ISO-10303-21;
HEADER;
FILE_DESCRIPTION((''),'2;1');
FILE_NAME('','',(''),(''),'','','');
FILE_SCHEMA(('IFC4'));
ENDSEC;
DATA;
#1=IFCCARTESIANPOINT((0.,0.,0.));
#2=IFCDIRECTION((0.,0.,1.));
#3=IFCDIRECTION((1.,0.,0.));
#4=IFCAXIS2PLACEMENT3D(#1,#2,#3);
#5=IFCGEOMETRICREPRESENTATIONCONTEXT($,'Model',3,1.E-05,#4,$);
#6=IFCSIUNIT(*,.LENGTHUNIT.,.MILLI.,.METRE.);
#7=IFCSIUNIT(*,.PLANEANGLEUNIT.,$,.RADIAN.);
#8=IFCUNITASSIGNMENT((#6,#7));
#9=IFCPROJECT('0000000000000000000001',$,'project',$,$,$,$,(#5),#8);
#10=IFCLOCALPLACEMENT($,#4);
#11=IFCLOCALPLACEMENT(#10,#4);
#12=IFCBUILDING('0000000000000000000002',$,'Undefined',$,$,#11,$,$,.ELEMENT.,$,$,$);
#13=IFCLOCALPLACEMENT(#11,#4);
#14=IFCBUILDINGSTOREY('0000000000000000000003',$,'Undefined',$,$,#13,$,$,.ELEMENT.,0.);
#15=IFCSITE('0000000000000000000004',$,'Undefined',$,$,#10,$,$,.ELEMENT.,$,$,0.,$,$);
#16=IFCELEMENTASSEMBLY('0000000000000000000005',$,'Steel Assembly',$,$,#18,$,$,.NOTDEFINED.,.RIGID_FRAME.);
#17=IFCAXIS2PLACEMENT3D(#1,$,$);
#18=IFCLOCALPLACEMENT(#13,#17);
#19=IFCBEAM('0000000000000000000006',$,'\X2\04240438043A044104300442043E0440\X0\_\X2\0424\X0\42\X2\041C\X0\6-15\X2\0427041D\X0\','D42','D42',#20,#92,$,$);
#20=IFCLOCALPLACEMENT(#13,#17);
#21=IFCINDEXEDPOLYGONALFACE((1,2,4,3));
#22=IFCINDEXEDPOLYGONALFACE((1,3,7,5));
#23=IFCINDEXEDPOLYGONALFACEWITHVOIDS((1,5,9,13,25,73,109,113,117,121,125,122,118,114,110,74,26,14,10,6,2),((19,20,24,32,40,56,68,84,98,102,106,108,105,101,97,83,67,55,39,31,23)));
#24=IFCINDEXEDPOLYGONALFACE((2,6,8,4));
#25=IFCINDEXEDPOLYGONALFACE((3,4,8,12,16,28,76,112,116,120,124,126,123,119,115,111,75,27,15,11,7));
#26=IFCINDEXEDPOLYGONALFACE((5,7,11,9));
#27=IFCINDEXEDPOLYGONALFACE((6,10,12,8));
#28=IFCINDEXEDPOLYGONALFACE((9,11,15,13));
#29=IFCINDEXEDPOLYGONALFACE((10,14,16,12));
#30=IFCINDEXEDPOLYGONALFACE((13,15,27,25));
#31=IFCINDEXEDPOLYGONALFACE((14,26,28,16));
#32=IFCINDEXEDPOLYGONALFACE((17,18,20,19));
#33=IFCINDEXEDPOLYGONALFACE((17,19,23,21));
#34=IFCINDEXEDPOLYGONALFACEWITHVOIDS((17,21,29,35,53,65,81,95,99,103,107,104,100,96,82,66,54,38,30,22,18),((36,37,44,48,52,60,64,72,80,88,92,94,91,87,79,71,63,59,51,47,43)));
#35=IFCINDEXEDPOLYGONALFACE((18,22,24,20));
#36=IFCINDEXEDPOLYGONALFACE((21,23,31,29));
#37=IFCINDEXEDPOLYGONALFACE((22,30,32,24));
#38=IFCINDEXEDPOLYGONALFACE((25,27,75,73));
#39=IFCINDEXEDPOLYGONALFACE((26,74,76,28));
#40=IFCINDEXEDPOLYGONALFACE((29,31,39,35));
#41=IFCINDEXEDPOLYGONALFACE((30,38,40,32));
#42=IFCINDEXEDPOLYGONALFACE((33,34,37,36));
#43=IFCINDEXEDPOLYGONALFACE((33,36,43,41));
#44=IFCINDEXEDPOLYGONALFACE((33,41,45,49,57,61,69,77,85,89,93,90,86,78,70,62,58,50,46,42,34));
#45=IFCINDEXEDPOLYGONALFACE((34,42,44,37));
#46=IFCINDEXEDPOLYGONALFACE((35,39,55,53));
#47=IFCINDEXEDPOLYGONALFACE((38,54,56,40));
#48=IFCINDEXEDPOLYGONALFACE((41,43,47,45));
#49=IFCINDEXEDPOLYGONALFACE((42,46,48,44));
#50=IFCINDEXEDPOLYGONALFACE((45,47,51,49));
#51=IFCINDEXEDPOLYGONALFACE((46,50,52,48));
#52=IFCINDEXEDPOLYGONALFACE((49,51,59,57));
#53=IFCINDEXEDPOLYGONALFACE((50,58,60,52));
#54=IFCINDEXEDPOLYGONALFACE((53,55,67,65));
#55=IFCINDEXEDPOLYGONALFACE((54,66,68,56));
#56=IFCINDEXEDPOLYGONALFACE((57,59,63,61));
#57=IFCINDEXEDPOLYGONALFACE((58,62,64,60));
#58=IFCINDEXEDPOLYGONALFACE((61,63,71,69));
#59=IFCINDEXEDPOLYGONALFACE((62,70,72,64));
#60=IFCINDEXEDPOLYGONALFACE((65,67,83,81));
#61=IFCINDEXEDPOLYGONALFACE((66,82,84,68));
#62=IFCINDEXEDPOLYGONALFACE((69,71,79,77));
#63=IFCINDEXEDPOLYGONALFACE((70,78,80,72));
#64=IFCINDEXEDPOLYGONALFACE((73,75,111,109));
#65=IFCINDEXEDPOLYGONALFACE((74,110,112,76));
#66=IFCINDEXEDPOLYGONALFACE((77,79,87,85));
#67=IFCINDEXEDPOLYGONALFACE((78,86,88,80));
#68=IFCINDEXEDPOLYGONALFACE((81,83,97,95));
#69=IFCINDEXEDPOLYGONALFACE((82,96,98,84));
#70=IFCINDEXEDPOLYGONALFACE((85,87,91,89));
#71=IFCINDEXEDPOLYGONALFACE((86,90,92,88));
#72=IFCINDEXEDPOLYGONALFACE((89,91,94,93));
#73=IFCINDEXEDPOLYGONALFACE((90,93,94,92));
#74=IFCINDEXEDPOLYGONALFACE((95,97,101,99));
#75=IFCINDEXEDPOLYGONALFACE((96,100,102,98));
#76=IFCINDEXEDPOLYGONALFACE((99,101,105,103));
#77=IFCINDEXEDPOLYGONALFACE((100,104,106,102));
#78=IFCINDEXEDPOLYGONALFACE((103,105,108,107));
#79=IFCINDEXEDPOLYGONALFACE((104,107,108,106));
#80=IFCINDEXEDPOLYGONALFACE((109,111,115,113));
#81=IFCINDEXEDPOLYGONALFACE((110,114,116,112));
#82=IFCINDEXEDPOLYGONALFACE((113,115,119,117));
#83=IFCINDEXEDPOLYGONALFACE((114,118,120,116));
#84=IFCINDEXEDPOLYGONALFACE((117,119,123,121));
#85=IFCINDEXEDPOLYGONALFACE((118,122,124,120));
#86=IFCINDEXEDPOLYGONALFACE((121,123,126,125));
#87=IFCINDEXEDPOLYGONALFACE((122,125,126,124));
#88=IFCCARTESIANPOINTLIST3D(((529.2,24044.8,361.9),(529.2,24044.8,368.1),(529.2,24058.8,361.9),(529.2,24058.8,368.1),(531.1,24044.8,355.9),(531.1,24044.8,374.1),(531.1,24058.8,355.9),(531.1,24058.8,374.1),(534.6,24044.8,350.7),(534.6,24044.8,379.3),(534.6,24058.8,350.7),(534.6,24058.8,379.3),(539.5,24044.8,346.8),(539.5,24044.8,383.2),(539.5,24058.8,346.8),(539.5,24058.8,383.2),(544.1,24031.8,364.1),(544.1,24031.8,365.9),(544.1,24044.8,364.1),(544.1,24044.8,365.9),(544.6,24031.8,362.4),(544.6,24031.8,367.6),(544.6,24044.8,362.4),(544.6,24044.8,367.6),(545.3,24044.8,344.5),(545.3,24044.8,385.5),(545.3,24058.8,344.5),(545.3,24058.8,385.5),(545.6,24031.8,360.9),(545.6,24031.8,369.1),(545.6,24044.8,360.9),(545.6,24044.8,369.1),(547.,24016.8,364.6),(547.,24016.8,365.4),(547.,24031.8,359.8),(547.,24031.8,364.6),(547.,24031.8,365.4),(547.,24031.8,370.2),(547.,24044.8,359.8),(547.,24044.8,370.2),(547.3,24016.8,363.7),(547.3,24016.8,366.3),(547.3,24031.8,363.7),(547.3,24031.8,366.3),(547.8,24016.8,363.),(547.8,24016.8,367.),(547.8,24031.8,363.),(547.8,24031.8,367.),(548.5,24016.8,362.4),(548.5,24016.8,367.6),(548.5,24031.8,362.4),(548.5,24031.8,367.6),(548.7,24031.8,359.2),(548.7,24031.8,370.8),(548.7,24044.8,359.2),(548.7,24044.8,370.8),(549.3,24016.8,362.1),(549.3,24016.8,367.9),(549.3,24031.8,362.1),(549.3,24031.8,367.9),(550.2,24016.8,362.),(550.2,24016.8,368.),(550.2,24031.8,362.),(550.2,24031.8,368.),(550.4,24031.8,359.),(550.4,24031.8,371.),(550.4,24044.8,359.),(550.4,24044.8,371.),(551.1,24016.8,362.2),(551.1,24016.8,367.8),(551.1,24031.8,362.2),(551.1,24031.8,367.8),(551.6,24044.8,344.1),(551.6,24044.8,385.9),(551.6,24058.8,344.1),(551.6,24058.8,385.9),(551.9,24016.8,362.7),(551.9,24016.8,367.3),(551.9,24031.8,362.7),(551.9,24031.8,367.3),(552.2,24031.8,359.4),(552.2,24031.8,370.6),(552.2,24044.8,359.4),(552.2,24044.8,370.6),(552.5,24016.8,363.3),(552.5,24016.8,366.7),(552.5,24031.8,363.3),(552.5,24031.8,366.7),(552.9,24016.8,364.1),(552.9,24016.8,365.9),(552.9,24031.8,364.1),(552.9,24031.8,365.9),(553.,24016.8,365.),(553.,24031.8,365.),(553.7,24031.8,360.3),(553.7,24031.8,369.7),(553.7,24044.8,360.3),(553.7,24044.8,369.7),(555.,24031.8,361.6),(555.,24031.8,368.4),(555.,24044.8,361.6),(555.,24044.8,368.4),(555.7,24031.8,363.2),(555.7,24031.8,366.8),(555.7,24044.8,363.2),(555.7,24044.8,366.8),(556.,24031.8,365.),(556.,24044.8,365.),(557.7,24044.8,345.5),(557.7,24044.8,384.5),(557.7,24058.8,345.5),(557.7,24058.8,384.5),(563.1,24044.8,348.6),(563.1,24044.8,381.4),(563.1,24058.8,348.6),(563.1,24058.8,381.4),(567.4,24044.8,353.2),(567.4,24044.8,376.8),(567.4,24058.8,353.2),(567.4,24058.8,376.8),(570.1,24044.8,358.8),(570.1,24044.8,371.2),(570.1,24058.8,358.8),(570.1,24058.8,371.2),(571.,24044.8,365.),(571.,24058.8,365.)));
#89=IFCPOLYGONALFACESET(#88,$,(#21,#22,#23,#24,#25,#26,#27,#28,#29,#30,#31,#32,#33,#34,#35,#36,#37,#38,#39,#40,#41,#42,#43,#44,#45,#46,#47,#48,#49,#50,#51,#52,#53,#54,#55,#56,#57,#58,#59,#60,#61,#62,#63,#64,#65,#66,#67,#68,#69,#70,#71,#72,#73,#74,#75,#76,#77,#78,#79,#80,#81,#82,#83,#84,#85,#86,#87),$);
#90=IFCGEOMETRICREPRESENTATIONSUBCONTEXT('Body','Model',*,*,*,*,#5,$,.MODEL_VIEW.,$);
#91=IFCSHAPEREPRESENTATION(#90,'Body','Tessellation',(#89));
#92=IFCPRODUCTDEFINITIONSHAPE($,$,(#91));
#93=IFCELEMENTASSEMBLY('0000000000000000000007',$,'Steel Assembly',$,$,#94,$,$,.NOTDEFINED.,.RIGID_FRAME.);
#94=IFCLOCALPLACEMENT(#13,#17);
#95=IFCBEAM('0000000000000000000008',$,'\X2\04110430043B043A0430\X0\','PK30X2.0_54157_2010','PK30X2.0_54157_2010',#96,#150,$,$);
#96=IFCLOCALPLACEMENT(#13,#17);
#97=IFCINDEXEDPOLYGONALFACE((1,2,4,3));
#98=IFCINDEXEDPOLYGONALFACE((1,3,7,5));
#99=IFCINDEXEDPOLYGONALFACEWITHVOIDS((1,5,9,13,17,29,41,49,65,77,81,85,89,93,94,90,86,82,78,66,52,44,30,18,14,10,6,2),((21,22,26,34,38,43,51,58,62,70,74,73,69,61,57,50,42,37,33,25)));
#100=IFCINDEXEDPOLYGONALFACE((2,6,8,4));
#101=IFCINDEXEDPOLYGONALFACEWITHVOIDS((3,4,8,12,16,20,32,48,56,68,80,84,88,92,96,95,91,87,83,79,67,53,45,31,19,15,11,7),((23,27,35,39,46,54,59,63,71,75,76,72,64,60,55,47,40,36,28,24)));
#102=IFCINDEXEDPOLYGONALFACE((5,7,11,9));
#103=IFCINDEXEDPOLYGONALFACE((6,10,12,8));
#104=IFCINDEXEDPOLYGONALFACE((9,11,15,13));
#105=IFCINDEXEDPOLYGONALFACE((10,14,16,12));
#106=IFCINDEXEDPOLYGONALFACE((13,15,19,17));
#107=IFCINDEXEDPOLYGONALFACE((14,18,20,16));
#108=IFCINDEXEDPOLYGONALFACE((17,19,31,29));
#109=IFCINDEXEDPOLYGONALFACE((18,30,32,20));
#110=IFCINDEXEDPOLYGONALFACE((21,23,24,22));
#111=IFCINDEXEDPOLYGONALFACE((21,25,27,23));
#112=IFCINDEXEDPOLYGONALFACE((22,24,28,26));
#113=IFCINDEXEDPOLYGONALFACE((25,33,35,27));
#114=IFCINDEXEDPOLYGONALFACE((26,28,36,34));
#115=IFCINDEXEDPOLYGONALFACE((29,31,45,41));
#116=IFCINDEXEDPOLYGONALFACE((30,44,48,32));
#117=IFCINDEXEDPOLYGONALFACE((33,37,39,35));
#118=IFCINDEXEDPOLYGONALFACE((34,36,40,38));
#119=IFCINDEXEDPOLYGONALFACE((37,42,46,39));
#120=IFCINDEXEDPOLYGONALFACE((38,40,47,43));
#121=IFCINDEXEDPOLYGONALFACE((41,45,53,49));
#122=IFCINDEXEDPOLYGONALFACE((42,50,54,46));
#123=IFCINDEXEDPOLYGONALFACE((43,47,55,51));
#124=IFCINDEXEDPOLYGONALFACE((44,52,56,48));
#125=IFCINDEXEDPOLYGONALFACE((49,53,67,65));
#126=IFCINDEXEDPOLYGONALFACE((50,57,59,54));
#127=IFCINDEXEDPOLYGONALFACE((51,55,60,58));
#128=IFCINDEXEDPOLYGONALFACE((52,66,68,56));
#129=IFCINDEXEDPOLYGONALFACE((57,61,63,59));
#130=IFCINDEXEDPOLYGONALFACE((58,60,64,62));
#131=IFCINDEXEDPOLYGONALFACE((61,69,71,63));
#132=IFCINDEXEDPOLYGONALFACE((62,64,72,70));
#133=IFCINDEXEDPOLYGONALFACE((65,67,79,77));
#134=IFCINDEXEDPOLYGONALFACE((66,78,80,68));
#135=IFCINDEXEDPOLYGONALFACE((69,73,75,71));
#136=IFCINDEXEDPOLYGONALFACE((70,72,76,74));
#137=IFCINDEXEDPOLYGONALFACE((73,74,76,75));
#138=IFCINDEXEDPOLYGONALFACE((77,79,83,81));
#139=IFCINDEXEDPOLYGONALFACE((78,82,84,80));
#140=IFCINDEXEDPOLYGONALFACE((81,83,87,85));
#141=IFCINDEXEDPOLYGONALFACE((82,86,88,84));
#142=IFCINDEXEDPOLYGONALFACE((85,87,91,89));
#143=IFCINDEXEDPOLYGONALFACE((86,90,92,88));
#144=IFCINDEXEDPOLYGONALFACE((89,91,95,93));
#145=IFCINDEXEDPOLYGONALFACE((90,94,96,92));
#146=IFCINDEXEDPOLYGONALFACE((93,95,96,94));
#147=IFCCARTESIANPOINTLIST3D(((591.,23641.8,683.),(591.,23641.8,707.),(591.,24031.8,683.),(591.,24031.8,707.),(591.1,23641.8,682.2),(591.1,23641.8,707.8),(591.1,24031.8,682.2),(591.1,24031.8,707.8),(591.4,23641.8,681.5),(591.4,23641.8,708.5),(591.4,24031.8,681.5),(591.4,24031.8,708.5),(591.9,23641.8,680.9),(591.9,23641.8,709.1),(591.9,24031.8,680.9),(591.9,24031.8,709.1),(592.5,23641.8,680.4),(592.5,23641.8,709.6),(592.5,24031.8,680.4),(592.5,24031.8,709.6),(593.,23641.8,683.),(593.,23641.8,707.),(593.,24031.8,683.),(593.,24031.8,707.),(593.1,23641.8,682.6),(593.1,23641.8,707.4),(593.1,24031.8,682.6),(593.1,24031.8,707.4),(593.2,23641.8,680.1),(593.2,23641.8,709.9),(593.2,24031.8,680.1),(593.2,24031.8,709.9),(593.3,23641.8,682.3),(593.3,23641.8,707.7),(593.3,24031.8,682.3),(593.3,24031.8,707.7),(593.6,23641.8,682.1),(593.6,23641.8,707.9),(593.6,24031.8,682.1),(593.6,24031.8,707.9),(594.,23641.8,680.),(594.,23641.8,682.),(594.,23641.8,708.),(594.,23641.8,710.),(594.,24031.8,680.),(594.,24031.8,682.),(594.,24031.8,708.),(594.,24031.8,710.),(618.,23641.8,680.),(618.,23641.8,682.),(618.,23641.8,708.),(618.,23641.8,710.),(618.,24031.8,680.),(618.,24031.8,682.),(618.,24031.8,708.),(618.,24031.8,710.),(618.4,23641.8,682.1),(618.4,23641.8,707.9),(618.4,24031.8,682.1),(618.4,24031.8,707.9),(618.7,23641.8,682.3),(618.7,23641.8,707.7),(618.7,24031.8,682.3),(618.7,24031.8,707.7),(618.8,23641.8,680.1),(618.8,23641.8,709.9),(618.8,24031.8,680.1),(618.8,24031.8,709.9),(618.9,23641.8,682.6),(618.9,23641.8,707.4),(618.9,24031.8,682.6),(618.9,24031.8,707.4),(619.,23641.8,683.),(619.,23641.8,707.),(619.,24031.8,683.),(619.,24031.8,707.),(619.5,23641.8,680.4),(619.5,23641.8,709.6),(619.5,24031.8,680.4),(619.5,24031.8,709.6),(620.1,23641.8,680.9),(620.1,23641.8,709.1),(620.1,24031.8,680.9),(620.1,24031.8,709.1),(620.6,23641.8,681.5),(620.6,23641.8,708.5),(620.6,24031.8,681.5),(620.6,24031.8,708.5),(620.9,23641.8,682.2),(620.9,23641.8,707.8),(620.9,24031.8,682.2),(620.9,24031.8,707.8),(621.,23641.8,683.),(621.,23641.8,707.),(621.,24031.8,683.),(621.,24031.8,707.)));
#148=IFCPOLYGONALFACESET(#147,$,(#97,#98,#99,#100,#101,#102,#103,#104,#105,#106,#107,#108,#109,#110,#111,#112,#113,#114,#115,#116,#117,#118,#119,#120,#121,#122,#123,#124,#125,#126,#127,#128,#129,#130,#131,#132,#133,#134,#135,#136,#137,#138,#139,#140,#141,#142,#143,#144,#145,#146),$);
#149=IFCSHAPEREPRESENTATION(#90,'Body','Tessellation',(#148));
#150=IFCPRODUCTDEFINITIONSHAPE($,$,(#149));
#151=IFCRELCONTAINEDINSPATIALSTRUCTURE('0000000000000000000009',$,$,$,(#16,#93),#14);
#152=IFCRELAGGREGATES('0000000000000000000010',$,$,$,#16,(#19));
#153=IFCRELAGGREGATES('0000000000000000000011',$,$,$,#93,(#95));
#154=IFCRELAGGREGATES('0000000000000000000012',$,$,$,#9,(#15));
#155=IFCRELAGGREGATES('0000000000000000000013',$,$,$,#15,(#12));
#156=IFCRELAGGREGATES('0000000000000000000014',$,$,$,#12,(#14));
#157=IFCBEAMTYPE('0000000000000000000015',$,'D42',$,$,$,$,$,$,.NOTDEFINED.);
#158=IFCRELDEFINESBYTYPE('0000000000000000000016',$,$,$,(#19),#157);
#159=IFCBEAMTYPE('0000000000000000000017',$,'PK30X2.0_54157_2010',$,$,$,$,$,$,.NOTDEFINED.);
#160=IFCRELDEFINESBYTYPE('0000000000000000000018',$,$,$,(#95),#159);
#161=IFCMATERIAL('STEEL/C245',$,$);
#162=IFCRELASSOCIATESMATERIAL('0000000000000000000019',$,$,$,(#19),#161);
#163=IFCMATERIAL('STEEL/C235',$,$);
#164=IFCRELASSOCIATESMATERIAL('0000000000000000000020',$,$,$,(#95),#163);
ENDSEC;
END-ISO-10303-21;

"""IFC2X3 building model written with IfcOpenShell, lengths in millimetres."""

from ifc_helpers import new_model, si_unit, frame, origin_with_axes, origin_2d_with_axis, place, context, subcontext, project, spatial, hollow_rectangle, circle, extrude, boolean, material, type_object, element, aggregate, save


model = new_model("IFC2X3")

# Units and contexts
model_context = context("Model", 3, precision=1e-05, world=origin_with_axes())
body_context = subcontext(model_context, "Body", "Model", "MODEL_VIEW")
ifc_project = project(units=[si_unit("LENGTHUNIT", "METRE", prefix="MILLI"), si_unit("PLANEANGLEUNIT", "RADIAN")], contexts=[model_context])

# Site, building, storey
site_placement = place(None, origin_with_axes())
site = spatial("IfcSite", under=ifc_project, at=site_placement, Name="Undefined", CompositionType="ELEMENT", RefElevation=0.0)
building_placement = place(site_placement, origin_with_axes())
building = spatial("IfcBuilding", under=site, at=building_placement, Name="Undefined", CompositionType="ELEMENT")
storey_placement = place(building_placement, origin_with_axes())
storey = spatial("IfcBuildingStorey", under=building, at=storey_placement, Name="Undefined", CompositionType="ELEMENT", Elevation=0.0)

# Element assemblies, beams
ifc_material_1 = material(Name="STEEL/C235")
ifc_material_2 = material(Name="STEEL/C245")
assembly_1_placement = place(storey_placement, origin_with_axes())
assembly_1 = element("IfcElementAssembly", 1, at=assembly_1_placement, inside=storey, Name="Steel Assembly", AssemblyPlace="NOTDEFINED", PredefinedType="RIGID_FRAME")
beam_type_1 = type_object("IfcBeamType", Name="D42", PredefinedType="NOTDEFINED")
beam_1_placement = place(assembly_1_placement, frame((550.0, 24016.8, 365.0), z_axis=(0.0, 0.0, 1.0), x_axis=(0.0, 1.0, 0.0)))
solid_1 = boolean("DIFFERENCE", extrude(circle(Radius=21.0, at=origin_2d_with_axis()), frame((28.0, 0.0, 0.0), z_axis=(-1.0, 0.0, 0.0), x_axis=(0.0, -1.0, 0.0)), (0.0, 0.0, 1.0), 13.0), extrude(circle(Radius=6.0, at=origin_2d_with_axis()), frame((28.0, 0.0, 0.0), z_axis=(-1.0, 0.0, 0.0), x_axis=(0.0, -1.0, 0.0)), (0.0, 0.0, 1.0), 13.0))
solid_2 = boolean("DIFFERENCE", extrude(circle(Radius=21.0, at=origin_2d_with_axis()), frame((15.0, 0.0, 0.0), z_axis=(-1.0, 0.0, 0.0), x_axis=(0.0, -1.0, 0.0)), (0.0, 0.0, 1.0), 15.0), extrude(circle(Radius=3.0, at=origin_2d_with_axis()), frame((15.0, 0.0, 0.0), z_axis=(-1.0, 0.0, 0.0), x_axis=(0.0, -1.0, 0.0)), (0.0, 0.0, 1.0), 15.0))
beam_1 = element("IfcBeam", 2, at=beam_1_placement, type_object=beam_type_1, material=ifc_material_2, Name="Фиксатор_Ф42М6-15ЧН", Description="D42", ObjectType="D42", context=body_context, shape_type="CSG", body=[
    boolean("DIFFERENCE", boolean("DIFFERENCE", extrude(circle(Radius=21.0, at=origin_2d_with_axis()), frame((42.0, 0.0, 0.0), z_axis=(-1.0, 0.0, 0.0), x_axis=(0.0, -1.0, 0.0)), (0.0, 0.0, 1.0), 42.0), solid_1), solid_2),
])
aggregate(assembly_1, [beam_1])
assembly_2_placement = place(storey_placement, origin_with_axes())
assembly_2 = element("IfcElementAssembly", 3, at=assembly_2_placement, inside=storey, Name="Steel Assembly", AssemblyPlace="NOTDEFINED", PredefinedType="RIGID_FRAME")
beam_type_2 = type_object("IfcBeamType", Name="PK30X2.0_54157_2010", PredefinedType="NOTDEFINED")
beam_2_placement = place(assembly_2_placement, frame((606.0, 24031.8, 695.0), z_axis=(-1.0, 0.0, 0.0), x_axis=(0.0, -1.0, 0.0)))
beam_2 = element("IfcBeam", 4, at=beam_2_placement, type_object=beam_type_2, material=ifc_material_1, Name="Балка", Description="PK30X2.0_54157_2010", ObjectType="PK30X2.0_54157_2010", context=body_context, shape_type="SweptSolid", body=[
    extrude(hollow_rectangle(XDim=30.0, YDim=30.0, WallThickness=2.0, InnerFilletRadius=1.0, OuterFilletRadius=3.0, at=origin_2d_with_axis()), frame((390.0, 0.0, 0.0), z_axis=(-1.0, 0.0, 0.0), x_axis=(0.0, -1.0, 0.0)), (0.0, 0.0, 1.0), 390.0),
])
aggregate(assembly_2, [beam_2])

save(model, "model.ifc")
